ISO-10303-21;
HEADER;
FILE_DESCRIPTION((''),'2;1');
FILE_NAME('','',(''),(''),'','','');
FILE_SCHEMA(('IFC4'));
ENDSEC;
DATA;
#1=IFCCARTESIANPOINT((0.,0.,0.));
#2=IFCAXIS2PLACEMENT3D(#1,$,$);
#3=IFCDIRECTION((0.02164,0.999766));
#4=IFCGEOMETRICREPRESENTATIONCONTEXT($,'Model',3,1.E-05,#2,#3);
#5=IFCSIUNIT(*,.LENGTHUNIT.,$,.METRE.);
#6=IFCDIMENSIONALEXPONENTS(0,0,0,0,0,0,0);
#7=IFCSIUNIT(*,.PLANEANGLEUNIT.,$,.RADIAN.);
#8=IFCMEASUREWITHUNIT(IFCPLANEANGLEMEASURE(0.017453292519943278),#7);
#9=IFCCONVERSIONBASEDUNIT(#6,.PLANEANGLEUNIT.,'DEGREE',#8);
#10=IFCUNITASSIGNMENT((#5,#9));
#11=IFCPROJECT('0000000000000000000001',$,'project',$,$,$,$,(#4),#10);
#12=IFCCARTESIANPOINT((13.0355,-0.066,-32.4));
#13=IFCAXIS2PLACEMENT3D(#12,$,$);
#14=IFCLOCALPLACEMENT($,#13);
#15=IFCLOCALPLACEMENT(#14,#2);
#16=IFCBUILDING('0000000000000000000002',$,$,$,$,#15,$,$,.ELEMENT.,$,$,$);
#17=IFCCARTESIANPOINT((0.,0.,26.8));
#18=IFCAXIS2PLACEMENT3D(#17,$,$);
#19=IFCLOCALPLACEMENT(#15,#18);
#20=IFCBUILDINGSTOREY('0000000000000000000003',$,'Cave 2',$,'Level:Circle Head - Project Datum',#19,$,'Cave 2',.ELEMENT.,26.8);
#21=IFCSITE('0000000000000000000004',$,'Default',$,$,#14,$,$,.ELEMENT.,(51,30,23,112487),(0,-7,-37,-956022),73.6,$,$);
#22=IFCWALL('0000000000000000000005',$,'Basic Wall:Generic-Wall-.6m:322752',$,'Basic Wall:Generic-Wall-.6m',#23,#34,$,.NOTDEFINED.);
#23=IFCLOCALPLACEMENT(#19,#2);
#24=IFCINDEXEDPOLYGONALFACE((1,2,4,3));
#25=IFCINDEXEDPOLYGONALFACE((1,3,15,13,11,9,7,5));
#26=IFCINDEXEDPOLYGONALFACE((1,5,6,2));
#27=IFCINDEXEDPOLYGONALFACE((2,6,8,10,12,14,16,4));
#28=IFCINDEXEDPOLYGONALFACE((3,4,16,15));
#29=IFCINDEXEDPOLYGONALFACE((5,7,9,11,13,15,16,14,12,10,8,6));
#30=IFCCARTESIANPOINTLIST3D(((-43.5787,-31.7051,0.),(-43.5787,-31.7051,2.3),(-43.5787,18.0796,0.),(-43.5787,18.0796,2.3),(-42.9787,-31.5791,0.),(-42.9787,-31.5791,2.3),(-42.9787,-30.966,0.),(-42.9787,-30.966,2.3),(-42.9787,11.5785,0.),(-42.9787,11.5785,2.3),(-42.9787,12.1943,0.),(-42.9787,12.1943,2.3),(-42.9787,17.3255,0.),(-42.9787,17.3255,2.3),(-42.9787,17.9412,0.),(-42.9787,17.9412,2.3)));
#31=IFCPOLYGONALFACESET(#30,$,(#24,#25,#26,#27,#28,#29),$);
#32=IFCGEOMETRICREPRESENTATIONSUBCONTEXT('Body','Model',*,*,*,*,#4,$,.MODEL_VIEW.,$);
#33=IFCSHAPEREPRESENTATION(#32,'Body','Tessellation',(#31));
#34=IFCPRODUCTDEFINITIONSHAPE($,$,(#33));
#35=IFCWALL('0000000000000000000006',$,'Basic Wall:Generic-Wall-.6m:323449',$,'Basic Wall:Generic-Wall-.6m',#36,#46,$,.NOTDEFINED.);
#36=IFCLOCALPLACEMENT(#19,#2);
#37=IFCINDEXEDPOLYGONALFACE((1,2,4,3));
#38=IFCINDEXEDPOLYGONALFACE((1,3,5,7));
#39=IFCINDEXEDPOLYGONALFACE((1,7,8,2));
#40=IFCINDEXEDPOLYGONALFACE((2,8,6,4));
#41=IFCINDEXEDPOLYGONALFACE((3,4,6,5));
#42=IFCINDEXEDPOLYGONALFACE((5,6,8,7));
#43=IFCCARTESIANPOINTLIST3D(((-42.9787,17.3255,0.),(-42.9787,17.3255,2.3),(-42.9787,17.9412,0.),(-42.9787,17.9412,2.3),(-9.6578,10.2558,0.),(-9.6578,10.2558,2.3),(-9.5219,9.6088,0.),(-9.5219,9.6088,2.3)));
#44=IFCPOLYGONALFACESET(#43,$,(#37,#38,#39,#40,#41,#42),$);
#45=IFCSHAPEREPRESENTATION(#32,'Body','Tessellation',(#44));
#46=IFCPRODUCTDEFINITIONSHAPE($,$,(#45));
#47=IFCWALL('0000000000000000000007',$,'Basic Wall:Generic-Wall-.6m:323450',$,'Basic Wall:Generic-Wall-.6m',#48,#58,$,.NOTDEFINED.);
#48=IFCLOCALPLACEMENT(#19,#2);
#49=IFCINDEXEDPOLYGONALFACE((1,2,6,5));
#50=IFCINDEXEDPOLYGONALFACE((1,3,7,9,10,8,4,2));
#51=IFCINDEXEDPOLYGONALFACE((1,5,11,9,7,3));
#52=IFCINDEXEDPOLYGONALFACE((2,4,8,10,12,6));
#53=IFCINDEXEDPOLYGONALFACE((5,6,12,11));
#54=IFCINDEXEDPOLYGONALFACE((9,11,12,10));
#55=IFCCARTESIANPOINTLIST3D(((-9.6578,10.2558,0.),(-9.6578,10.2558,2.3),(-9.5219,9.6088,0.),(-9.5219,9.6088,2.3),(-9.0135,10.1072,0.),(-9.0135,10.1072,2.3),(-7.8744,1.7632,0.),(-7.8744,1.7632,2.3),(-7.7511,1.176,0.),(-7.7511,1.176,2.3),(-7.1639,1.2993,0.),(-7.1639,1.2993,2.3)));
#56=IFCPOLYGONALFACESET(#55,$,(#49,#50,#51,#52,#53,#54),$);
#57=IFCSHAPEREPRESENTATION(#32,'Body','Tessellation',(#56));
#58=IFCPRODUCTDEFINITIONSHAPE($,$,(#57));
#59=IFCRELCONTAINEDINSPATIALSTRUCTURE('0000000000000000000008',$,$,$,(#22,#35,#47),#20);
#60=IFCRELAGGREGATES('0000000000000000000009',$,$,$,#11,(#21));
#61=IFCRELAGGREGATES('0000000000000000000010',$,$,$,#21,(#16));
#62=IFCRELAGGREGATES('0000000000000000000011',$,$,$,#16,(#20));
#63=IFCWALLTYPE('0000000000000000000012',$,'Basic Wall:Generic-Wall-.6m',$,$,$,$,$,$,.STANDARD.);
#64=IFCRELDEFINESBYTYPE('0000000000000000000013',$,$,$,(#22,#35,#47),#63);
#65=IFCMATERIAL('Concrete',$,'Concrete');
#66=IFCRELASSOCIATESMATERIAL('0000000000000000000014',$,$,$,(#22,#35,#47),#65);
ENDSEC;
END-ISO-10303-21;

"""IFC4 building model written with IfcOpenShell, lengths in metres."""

from ifc_helpers import new_model, entity, si_unit, converted_unit, direction, frame, origin, place, context, subcontext, project, spatial, indexed_curve, outline, extrude, material, type_object, element, save


model = new_model("IFC4")

# Units and contexts
model_context = context("Model", 3, precision=1e-05, world=origin(), true_north=direction((0.02164, 0.999766)))
body_context = subcontext(model_context, "Body", "Model", "MODEL_VIEW")
ifc_project = project(units=[si_unit("LENGTHUNIT", "METRE"), converted_unit("PLANEANGLEUNIT", "DEGREE", entity("IfcPlaneAngleMeasure", 0.017453292519943278), si_unit("PLANEANGLEUNIT", "RADIAN"), dimensions=[0, 0, 0, 0, 0, 0, 0])], contexts=[model_context])

# Site, building, storey
site_placement = place(None, frame((13.0355, -0.066, -32.4)))
site = spatial("IfcSite", under=ifc_project, at=site_placement, Name="Default", CompositionType="ELEMENT", RefLatitude=(51, 30, 23, 112487), RefLongitude=(0, -7, -37, -956022), RefElevation=73.6)
building_placement = place(site_placement, origin())
building = spatial("IfcBuilding", under=site, at=building_placement, CompositionType="ELEMENT")
storey_placement = place(building_placement, frame((0.0, 0.0, 26.8)))
storey = spatial("IfcBuildingStorey", under=building, at=storey_placement, Name="Cave 2", ObjectType="Level:Circle Head - Project Datum", LongName="Cave 2", CompositionType="ELEMENT", Elevation=26.8)

# Shared definitions
ifc_material = material(Name="Concrete", Category="Concrete")

# Walls
wall_type = type_object("IfcWallType", Name="Basic Wall:Generic-Wall-.6m", PredefinedType="STANDARD")
wall_1_placement = place(storey_placement, frame((-43.2787, -31.7051, 0.0), z_axis=(0.0, 0.0, 1.0), x_axis=(0.0, 1.0, 0.0)))
element("IfcWall", 1, at=wall_1_placement, inside=storey, type_object=wall_type, material=ifc_material, Name="Basic Wall:Generic-Wall-.6m:322752", ObjectType="Basic Wall:Generic-Wall-.6m", PredefinedType="NOTDEFINED", context=body_context, shape_type="SweptSolid", body=[
    extrude(outline(indexed_curve([(49.6463, -0.3), (49.7847, 0.3), (0.0, 0.3), (0.126, -0.3), (0.7391, -0.3), (43.2836, -0.3), (43.8994, -0.3), (49.0305, -0.3), (49.6463, -0.3)], self_intersect=False)), origin(), (0.0, 0.0, 1.0), 2.3),
])
wall_2_placement = place(storey_placement, frame((-43.0461, 17.6489, 0.0), z_axis=(0.0, 0.0, 1.0), x_axis=(0.974417, -0.224746, 0.0)))
element("IfcWall", 2, at=wall_2_placement, inside=storey, type_object=wall_type, material=ifc_material, Name="Basic Wall:Generic-Wall-.6m:323449", ObjectType="Basic Wall:Generic-Wall-.6m", PredefinedType="NOTDEFINED", context=body_context, shape_type="SweptSolid", body=[
    extrude(outline(indexed_curve([(34.4735, -0.3), (34.1957, 0.3), (0.0, 0.3), (0.1384, -0.3), (34.4735, -0.3)], self_intersect=False)), origin(), (0.0, 0.0, 1.0), 2.3),
])
wall_3_placement = place(storey_placement, frame((-9.3642, 10.3175, 0.0), z_axis=(0.0, 0.0, 1.0), x_axis=(0.20551, -0.978655, 0.0)))
element("IfcWall", 3, at=wall_3_placement, inside=storey, type_object=wall_type, material=ifc_material, Name="Basic Wall:Generic-Wall-.6m:323450", ObjectType="Basic Wall:Generic-Wall-.6m", PredefinedType="NOTDEFINED", context=body_context, shape_type="SweptSolid", body=[
    extrude(outline(indexed_curve([(9.2778, -0.3), (9.2778, 0.3), (0.2778, 0.3), (0.0, -0.3), (0.6612, -0.3), (8.6778, -0.3), (9.2778, -0.3)], self_intersect=False)), origin(), (0.0, 0.0, 1.0), 2.3),
])

save(model, "model.ifc")
